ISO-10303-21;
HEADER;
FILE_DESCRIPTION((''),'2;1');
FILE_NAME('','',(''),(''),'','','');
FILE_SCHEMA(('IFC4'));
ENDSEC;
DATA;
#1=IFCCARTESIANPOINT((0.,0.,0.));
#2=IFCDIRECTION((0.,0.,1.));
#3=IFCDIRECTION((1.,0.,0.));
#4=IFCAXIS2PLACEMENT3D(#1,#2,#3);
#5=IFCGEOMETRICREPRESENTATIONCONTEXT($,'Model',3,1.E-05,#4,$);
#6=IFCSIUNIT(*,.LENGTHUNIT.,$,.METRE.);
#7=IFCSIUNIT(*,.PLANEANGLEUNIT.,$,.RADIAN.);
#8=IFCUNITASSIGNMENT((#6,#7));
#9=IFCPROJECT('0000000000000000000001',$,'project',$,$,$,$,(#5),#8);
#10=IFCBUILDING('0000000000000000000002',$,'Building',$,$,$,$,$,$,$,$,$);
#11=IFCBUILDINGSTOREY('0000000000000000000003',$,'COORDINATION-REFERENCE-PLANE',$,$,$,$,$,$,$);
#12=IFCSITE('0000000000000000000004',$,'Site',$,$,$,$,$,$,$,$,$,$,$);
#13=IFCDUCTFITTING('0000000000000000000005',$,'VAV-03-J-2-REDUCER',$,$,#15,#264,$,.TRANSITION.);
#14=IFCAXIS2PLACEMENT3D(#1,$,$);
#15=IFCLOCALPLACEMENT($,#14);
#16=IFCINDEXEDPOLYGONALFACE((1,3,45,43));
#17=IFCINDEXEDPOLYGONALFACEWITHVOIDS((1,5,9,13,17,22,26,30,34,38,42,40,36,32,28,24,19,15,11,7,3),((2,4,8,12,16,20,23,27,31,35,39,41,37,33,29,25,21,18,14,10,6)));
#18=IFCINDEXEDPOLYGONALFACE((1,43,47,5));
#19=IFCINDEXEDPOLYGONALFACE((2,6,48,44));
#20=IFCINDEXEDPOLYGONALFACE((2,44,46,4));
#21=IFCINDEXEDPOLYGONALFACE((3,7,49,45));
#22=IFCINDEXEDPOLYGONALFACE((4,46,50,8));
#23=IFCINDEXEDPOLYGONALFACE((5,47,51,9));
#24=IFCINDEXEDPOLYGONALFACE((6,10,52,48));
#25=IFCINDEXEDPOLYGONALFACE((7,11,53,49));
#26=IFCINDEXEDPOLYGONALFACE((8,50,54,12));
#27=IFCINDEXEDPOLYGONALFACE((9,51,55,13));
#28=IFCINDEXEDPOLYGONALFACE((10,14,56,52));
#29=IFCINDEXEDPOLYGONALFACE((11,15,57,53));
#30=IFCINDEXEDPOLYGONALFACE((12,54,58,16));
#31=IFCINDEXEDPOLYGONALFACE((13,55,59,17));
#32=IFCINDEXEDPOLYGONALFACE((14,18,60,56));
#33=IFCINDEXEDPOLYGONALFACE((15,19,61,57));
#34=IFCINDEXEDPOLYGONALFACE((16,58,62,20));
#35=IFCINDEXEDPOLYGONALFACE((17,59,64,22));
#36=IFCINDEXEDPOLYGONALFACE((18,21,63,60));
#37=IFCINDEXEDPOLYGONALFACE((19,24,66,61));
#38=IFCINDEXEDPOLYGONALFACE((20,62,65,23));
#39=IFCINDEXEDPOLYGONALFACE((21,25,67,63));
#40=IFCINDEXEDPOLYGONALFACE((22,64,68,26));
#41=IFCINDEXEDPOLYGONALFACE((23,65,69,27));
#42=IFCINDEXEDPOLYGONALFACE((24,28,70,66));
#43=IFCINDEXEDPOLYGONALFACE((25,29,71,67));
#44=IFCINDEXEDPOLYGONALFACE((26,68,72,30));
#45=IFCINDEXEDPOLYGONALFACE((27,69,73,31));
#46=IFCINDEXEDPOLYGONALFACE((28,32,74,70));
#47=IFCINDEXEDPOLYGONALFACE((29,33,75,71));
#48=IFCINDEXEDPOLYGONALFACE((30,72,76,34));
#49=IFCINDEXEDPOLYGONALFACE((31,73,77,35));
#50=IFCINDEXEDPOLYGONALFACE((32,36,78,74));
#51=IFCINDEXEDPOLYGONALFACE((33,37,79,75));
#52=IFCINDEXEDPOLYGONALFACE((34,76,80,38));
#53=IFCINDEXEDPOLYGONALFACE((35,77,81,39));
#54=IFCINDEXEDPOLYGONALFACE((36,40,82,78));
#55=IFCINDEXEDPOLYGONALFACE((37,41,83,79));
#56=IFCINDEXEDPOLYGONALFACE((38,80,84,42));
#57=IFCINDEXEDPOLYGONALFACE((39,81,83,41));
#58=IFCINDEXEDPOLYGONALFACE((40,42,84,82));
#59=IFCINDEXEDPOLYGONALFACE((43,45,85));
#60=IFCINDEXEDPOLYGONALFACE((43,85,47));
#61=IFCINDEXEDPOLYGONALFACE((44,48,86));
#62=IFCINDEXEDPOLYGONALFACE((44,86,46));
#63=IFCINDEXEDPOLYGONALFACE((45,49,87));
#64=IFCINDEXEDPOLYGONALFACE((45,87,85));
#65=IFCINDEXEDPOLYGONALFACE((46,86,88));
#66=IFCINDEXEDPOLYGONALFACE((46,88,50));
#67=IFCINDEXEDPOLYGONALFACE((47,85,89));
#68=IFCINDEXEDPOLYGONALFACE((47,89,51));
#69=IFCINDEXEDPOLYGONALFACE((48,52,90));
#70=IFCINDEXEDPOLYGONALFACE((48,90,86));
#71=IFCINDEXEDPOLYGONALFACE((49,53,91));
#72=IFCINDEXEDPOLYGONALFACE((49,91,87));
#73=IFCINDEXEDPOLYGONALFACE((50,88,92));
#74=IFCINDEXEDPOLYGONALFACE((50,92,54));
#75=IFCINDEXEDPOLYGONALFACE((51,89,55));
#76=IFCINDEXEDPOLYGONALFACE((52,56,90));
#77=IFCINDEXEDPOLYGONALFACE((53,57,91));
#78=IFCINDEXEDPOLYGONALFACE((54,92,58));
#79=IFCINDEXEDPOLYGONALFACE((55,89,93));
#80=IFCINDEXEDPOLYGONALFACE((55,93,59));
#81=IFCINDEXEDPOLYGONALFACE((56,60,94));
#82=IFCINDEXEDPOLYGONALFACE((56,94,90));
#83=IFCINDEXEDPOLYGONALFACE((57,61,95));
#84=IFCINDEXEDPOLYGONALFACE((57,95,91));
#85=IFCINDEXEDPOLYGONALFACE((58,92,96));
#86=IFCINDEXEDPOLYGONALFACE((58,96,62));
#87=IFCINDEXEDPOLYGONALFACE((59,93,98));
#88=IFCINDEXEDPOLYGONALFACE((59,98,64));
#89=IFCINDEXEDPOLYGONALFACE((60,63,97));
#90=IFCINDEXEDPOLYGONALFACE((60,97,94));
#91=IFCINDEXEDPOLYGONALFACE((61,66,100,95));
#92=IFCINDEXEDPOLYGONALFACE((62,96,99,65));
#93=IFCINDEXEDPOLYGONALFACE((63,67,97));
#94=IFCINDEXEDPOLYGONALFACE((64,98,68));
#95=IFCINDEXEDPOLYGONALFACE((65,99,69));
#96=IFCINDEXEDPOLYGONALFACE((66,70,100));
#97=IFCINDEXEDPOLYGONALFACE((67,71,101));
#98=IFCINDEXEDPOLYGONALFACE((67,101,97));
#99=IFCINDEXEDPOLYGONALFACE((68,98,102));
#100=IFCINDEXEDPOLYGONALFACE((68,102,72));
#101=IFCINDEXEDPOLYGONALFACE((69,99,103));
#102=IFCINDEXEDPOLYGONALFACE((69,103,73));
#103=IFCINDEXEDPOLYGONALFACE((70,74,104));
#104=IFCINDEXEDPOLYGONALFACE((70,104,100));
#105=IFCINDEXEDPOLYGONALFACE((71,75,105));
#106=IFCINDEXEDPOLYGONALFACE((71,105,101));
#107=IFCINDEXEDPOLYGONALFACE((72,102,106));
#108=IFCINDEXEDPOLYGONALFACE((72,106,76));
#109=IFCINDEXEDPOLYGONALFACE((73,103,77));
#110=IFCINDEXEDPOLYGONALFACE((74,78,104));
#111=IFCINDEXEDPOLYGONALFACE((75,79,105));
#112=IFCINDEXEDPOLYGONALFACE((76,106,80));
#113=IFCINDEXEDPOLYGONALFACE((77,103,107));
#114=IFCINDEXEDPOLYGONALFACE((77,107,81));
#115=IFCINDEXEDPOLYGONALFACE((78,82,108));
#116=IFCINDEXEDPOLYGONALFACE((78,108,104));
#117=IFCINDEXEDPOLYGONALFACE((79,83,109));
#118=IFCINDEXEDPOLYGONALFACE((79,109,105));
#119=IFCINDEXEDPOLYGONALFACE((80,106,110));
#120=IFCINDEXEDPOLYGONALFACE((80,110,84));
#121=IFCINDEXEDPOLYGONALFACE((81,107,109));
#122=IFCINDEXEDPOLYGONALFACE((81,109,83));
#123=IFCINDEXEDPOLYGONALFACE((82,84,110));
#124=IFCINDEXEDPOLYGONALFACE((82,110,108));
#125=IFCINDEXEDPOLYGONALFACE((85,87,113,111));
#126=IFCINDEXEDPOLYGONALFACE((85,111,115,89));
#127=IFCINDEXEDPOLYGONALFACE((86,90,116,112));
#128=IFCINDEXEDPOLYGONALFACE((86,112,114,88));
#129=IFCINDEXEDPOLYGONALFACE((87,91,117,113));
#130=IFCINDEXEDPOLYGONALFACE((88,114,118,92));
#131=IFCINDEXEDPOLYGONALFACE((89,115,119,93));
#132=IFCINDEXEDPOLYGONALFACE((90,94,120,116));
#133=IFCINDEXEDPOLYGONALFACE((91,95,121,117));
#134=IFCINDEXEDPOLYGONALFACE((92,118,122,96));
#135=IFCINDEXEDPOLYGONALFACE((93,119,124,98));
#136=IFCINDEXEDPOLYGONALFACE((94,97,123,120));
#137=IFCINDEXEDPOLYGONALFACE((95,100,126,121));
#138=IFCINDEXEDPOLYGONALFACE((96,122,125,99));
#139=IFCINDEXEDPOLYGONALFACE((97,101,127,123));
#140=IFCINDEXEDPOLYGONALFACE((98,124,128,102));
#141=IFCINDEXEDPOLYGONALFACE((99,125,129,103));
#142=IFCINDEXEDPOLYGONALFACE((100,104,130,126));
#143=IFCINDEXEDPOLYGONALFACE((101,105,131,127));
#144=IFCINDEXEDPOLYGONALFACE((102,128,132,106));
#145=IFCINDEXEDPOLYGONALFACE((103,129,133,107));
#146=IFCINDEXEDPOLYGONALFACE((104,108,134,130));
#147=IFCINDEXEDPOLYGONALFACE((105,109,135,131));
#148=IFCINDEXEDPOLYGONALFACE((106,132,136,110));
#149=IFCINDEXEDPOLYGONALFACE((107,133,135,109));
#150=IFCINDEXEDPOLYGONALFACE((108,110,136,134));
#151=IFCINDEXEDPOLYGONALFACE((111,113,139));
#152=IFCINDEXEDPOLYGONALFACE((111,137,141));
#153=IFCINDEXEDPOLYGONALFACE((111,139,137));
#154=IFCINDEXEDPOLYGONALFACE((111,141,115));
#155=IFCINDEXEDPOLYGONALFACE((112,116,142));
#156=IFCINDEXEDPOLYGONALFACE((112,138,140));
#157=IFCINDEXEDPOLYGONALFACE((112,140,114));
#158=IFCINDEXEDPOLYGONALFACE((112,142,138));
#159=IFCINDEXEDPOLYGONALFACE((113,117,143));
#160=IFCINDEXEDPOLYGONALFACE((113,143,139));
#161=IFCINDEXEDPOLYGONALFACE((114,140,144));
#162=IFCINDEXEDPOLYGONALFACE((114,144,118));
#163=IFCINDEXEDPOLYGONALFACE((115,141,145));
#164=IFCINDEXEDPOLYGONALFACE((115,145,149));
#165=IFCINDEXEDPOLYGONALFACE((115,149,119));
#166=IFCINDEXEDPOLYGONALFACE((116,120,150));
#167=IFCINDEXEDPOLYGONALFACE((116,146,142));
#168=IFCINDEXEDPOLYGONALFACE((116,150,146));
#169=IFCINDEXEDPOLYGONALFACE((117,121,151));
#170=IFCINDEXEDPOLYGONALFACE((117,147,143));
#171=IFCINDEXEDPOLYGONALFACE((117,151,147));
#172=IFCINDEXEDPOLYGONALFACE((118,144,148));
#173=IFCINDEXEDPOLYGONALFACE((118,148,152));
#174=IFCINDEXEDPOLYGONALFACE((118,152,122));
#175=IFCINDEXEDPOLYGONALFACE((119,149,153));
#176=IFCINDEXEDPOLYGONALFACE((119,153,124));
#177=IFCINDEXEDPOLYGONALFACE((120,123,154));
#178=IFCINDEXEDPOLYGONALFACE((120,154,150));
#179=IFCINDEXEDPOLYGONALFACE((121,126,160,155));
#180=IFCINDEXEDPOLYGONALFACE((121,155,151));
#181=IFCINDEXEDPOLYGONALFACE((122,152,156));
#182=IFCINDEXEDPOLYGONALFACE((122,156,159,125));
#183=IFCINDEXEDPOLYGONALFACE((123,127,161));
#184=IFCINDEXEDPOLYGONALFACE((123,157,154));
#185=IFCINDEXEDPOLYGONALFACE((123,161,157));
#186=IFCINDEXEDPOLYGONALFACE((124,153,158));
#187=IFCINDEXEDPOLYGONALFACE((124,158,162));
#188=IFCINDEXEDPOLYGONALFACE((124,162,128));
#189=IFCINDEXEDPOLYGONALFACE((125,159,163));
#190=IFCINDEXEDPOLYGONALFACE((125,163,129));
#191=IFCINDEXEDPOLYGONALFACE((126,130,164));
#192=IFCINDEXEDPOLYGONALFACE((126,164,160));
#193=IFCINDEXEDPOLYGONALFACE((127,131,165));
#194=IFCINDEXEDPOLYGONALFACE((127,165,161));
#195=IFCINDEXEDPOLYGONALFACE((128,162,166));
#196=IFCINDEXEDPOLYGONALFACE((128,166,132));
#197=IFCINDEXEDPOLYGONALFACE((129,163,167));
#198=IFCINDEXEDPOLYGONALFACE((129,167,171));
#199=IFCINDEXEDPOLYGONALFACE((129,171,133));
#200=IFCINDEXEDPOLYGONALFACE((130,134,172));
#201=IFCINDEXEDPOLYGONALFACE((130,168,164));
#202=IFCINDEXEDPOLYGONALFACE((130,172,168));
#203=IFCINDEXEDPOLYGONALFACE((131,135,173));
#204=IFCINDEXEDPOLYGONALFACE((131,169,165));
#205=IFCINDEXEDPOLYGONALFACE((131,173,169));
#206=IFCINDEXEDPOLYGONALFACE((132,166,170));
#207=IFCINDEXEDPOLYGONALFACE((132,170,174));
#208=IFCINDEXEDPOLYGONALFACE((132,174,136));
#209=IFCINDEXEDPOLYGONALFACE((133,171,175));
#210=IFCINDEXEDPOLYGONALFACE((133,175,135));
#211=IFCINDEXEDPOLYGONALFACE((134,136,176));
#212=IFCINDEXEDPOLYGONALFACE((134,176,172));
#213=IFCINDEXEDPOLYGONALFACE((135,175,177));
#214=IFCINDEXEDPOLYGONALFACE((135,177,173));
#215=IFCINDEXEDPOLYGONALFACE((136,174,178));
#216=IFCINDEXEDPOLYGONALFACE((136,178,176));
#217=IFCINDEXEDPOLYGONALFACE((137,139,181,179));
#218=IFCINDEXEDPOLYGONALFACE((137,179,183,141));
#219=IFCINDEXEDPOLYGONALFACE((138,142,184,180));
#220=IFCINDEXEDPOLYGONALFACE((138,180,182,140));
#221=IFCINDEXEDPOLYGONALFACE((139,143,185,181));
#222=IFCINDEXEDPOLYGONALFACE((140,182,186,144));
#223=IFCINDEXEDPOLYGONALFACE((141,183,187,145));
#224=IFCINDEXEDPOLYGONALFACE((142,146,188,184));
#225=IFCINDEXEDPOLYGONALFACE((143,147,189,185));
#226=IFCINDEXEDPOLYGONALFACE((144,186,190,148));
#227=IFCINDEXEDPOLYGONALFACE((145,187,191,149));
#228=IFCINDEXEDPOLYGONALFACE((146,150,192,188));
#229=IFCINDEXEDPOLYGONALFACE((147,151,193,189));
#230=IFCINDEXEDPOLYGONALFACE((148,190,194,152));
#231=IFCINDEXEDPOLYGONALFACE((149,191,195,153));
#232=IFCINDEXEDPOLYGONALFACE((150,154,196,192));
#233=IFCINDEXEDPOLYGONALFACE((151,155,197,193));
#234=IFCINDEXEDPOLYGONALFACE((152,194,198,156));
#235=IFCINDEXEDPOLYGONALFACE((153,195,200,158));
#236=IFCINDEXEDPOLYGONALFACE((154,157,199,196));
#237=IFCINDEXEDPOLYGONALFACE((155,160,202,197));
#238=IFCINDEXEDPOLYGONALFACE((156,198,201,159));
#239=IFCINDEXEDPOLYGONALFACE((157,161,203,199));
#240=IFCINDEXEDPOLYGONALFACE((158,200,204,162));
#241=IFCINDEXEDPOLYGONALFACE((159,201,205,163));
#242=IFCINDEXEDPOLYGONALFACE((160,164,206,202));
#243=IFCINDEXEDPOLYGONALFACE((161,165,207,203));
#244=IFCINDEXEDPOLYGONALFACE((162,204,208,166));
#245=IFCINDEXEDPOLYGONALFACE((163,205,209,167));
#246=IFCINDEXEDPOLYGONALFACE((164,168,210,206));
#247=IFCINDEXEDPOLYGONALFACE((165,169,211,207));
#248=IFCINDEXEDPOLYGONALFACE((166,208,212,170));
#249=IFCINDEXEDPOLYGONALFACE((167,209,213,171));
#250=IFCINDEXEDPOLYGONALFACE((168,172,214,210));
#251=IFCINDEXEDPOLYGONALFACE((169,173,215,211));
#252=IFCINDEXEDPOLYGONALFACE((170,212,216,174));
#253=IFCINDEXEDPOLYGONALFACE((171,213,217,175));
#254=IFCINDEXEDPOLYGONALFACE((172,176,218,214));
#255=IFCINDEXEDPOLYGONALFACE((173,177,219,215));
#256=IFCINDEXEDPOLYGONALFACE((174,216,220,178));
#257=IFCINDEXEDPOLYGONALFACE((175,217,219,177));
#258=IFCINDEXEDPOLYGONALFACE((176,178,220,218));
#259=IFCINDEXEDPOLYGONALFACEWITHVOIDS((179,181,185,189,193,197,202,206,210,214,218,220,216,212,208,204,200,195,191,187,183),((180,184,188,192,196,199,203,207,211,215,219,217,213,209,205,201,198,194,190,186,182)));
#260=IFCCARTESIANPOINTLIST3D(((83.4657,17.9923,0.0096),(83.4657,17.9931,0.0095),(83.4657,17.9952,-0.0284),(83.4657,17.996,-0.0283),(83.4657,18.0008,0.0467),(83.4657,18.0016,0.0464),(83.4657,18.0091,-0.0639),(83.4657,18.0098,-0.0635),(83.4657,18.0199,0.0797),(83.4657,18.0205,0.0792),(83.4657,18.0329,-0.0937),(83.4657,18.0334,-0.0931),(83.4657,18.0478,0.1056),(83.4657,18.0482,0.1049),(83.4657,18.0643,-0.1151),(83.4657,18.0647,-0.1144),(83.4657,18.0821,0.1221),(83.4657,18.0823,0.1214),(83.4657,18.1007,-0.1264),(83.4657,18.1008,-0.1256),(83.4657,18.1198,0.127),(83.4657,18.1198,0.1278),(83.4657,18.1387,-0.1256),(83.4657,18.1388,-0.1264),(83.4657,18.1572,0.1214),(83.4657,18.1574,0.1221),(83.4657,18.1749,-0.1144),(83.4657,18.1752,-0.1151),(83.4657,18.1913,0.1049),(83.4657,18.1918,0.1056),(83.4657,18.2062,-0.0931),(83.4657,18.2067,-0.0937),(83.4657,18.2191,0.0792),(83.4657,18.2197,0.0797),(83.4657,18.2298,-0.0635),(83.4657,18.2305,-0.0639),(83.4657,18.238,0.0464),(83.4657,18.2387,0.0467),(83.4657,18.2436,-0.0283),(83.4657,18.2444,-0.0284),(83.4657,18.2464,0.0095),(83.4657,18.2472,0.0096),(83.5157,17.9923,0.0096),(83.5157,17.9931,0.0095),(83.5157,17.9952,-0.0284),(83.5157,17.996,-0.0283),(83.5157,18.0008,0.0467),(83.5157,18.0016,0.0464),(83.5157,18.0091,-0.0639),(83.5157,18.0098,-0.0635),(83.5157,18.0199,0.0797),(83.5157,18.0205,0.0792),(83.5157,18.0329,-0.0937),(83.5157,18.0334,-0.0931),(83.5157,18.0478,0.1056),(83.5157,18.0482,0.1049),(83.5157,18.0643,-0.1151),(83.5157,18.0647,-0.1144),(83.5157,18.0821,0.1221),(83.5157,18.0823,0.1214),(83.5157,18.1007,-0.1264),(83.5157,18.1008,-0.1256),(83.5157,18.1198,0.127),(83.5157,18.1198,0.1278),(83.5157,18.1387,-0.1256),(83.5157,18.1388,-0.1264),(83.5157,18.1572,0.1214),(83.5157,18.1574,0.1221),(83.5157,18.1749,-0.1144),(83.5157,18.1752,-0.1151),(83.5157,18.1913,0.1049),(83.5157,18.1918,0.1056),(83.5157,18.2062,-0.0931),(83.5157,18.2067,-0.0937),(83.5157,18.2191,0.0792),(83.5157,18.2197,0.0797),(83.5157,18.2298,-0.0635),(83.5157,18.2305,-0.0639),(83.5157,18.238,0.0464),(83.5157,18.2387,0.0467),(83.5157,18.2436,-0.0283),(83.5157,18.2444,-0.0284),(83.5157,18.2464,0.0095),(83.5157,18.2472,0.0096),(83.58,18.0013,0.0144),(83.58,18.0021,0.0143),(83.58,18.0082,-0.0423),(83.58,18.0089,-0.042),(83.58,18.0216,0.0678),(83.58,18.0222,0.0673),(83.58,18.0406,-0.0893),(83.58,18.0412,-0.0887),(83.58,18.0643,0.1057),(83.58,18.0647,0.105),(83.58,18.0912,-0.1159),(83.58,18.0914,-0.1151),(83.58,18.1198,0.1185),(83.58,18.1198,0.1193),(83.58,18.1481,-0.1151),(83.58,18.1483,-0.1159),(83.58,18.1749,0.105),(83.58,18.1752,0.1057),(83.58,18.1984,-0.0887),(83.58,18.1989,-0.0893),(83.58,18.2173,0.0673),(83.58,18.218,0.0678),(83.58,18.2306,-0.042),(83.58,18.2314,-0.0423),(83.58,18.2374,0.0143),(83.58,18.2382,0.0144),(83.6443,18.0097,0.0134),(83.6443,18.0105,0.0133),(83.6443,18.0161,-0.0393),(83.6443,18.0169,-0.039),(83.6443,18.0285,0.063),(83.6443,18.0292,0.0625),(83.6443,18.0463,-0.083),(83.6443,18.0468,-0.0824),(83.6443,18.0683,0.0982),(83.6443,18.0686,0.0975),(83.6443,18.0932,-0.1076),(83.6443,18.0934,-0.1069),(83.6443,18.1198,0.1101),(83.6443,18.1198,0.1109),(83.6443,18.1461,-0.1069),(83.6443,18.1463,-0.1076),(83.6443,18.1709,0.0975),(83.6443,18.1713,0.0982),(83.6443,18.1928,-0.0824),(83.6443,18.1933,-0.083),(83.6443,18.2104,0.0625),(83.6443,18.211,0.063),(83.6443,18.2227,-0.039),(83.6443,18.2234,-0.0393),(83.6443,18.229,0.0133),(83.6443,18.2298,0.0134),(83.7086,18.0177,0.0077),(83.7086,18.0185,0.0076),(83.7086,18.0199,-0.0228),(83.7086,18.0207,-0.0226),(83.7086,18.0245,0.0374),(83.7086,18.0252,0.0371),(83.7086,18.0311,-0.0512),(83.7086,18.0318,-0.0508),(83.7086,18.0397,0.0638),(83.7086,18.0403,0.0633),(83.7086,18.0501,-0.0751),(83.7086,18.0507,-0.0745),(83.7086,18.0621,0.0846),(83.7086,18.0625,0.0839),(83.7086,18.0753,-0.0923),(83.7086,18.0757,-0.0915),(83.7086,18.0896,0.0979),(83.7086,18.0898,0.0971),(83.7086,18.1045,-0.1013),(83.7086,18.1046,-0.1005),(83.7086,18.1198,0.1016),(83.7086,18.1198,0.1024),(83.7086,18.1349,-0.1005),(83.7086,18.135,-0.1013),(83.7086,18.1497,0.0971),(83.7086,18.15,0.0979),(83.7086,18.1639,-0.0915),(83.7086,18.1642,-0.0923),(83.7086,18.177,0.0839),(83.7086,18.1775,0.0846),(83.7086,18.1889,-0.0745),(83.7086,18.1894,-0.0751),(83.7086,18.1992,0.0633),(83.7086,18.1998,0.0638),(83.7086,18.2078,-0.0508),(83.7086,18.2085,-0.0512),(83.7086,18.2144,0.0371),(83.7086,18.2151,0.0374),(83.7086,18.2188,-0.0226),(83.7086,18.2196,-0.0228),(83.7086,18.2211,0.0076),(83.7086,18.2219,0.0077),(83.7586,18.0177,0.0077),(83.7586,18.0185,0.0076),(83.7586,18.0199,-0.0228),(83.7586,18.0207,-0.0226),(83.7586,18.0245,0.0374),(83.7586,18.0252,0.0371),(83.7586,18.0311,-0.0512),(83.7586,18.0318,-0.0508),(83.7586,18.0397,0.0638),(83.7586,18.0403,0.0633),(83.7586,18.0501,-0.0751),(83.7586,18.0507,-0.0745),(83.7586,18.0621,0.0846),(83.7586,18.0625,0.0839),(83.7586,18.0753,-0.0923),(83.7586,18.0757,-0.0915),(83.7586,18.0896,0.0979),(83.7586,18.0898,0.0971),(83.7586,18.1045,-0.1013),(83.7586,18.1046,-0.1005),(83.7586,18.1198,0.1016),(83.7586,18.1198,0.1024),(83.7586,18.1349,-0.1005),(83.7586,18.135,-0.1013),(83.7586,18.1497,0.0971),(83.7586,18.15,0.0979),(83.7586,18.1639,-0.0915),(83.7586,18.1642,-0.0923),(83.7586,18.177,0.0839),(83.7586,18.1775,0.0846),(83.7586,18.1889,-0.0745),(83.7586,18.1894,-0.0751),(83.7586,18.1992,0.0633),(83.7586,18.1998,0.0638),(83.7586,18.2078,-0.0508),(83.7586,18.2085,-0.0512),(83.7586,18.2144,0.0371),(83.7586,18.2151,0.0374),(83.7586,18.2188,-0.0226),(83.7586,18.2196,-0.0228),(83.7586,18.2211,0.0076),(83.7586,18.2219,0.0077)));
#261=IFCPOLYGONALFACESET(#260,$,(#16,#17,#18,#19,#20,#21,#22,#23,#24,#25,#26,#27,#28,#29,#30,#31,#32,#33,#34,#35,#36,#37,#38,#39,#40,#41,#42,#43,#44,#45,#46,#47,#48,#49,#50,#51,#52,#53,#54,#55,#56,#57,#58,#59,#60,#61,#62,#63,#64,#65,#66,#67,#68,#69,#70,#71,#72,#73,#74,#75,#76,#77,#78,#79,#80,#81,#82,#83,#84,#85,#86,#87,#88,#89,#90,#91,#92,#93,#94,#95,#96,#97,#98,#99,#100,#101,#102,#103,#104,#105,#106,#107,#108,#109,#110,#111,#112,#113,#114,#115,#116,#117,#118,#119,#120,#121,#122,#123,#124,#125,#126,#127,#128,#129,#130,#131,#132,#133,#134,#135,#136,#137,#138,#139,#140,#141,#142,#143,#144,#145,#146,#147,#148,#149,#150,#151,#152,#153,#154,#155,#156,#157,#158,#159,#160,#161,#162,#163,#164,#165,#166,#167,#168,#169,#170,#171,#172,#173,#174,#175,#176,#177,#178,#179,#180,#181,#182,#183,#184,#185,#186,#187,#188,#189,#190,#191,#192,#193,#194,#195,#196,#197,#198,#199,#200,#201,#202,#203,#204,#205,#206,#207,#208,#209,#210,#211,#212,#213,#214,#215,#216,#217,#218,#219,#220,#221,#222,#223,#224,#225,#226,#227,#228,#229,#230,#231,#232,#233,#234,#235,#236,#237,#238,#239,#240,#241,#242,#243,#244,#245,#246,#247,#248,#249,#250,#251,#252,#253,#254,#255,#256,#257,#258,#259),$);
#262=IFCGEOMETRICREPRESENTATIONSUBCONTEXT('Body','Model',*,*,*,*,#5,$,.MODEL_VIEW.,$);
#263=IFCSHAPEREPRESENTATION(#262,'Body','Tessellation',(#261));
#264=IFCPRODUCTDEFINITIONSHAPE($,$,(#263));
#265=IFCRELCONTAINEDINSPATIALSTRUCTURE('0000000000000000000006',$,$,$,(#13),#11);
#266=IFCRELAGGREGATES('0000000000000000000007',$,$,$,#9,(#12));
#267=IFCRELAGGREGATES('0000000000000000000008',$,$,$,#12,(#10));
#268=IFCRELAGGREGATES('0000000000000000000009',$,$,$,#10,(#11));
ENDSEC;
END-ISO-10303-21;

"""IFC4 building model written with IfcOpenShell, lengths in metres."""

from ifc_helpers import new_model, entity, si_unit, frame, origin_with_axes, place, context, subcontext, project, spatial, element, save


model = new_model("IFC4")

# Units and contexts
model_context = context("Model", 3, precision=1e-05, world=origin_with_axes())
body_context_1 = subcontext(model_context, "Body", "Model", "MODEL_VIEW")
ifc_project = project(units=[si_unit("LENGTHUNIT", "METRE"), si_unit("PLANEANGLEUNIT", "RADIAN")], contexts=[model_context])

# Site, building, storey
site = spatial("IfcSite", under=ifc_project, Name="Site")
building = spatial("IfcBuilding", under=site, Name="Building")
storey = spatial("IfcBuildingStorey", under=building, Name="COORDINATION-REFERENCE-PLANE")

# Duct fitting
for number, where, z_axis, x_axis, name in (
    (1, (83.4657, 18.1198, 0.0), (0.0, 1.0, 0.0), (0.0, 0.0, 1.0), "VAV-03-J-2-REDUCER"),
):
    element("IfcDuctFitting", number, at=place(None, frame(where, z_axis=z_axis, x_axis=x_axis)), inside=storey, Name=name, PredefinedType="TRANSITION", context=body_context_1, shape_type="SweptSolid", body=[
        entity("IfcRevolvedAreaSolid", entity("IfcArbitraryClosedProfileDef", "AREA", None, entity("IfcPolyline", [entity("IfcCartesianPoint", [0.1278, 0.0]), entity("IfcCartesianPoint", [0.1278, 0.05]), entity("IfcCartesianPoint", [0.1024, 0.2429]), entity("IfcCartesianPoint", [0.1024, 0.2929]), entity("IfcCartesianPoint", [0.1016, 0.2929]), entity("IfcCartesianPoint", [0.1016, 0.2429]), entity("IfcCartesianPoint", [0.127, 0.05]), entity("IfcCartesianPoint", [0.127, 0.0]), entity("IfcCartesianPoint", [0.1278, 0.0])])), entity("IfcAxis2Placement3D", entity("IfcCartesianPoint", [0.0, 0.0, 0.0])), entity("IfcAxis1Placement", entity("IfcCartesianPoint", [0.0, 0.0, 0.0]), entity("IfcDirection", [0.0, 1.0, 0.0])), 6.283185),
    ])

save(model, "model.ifc")
